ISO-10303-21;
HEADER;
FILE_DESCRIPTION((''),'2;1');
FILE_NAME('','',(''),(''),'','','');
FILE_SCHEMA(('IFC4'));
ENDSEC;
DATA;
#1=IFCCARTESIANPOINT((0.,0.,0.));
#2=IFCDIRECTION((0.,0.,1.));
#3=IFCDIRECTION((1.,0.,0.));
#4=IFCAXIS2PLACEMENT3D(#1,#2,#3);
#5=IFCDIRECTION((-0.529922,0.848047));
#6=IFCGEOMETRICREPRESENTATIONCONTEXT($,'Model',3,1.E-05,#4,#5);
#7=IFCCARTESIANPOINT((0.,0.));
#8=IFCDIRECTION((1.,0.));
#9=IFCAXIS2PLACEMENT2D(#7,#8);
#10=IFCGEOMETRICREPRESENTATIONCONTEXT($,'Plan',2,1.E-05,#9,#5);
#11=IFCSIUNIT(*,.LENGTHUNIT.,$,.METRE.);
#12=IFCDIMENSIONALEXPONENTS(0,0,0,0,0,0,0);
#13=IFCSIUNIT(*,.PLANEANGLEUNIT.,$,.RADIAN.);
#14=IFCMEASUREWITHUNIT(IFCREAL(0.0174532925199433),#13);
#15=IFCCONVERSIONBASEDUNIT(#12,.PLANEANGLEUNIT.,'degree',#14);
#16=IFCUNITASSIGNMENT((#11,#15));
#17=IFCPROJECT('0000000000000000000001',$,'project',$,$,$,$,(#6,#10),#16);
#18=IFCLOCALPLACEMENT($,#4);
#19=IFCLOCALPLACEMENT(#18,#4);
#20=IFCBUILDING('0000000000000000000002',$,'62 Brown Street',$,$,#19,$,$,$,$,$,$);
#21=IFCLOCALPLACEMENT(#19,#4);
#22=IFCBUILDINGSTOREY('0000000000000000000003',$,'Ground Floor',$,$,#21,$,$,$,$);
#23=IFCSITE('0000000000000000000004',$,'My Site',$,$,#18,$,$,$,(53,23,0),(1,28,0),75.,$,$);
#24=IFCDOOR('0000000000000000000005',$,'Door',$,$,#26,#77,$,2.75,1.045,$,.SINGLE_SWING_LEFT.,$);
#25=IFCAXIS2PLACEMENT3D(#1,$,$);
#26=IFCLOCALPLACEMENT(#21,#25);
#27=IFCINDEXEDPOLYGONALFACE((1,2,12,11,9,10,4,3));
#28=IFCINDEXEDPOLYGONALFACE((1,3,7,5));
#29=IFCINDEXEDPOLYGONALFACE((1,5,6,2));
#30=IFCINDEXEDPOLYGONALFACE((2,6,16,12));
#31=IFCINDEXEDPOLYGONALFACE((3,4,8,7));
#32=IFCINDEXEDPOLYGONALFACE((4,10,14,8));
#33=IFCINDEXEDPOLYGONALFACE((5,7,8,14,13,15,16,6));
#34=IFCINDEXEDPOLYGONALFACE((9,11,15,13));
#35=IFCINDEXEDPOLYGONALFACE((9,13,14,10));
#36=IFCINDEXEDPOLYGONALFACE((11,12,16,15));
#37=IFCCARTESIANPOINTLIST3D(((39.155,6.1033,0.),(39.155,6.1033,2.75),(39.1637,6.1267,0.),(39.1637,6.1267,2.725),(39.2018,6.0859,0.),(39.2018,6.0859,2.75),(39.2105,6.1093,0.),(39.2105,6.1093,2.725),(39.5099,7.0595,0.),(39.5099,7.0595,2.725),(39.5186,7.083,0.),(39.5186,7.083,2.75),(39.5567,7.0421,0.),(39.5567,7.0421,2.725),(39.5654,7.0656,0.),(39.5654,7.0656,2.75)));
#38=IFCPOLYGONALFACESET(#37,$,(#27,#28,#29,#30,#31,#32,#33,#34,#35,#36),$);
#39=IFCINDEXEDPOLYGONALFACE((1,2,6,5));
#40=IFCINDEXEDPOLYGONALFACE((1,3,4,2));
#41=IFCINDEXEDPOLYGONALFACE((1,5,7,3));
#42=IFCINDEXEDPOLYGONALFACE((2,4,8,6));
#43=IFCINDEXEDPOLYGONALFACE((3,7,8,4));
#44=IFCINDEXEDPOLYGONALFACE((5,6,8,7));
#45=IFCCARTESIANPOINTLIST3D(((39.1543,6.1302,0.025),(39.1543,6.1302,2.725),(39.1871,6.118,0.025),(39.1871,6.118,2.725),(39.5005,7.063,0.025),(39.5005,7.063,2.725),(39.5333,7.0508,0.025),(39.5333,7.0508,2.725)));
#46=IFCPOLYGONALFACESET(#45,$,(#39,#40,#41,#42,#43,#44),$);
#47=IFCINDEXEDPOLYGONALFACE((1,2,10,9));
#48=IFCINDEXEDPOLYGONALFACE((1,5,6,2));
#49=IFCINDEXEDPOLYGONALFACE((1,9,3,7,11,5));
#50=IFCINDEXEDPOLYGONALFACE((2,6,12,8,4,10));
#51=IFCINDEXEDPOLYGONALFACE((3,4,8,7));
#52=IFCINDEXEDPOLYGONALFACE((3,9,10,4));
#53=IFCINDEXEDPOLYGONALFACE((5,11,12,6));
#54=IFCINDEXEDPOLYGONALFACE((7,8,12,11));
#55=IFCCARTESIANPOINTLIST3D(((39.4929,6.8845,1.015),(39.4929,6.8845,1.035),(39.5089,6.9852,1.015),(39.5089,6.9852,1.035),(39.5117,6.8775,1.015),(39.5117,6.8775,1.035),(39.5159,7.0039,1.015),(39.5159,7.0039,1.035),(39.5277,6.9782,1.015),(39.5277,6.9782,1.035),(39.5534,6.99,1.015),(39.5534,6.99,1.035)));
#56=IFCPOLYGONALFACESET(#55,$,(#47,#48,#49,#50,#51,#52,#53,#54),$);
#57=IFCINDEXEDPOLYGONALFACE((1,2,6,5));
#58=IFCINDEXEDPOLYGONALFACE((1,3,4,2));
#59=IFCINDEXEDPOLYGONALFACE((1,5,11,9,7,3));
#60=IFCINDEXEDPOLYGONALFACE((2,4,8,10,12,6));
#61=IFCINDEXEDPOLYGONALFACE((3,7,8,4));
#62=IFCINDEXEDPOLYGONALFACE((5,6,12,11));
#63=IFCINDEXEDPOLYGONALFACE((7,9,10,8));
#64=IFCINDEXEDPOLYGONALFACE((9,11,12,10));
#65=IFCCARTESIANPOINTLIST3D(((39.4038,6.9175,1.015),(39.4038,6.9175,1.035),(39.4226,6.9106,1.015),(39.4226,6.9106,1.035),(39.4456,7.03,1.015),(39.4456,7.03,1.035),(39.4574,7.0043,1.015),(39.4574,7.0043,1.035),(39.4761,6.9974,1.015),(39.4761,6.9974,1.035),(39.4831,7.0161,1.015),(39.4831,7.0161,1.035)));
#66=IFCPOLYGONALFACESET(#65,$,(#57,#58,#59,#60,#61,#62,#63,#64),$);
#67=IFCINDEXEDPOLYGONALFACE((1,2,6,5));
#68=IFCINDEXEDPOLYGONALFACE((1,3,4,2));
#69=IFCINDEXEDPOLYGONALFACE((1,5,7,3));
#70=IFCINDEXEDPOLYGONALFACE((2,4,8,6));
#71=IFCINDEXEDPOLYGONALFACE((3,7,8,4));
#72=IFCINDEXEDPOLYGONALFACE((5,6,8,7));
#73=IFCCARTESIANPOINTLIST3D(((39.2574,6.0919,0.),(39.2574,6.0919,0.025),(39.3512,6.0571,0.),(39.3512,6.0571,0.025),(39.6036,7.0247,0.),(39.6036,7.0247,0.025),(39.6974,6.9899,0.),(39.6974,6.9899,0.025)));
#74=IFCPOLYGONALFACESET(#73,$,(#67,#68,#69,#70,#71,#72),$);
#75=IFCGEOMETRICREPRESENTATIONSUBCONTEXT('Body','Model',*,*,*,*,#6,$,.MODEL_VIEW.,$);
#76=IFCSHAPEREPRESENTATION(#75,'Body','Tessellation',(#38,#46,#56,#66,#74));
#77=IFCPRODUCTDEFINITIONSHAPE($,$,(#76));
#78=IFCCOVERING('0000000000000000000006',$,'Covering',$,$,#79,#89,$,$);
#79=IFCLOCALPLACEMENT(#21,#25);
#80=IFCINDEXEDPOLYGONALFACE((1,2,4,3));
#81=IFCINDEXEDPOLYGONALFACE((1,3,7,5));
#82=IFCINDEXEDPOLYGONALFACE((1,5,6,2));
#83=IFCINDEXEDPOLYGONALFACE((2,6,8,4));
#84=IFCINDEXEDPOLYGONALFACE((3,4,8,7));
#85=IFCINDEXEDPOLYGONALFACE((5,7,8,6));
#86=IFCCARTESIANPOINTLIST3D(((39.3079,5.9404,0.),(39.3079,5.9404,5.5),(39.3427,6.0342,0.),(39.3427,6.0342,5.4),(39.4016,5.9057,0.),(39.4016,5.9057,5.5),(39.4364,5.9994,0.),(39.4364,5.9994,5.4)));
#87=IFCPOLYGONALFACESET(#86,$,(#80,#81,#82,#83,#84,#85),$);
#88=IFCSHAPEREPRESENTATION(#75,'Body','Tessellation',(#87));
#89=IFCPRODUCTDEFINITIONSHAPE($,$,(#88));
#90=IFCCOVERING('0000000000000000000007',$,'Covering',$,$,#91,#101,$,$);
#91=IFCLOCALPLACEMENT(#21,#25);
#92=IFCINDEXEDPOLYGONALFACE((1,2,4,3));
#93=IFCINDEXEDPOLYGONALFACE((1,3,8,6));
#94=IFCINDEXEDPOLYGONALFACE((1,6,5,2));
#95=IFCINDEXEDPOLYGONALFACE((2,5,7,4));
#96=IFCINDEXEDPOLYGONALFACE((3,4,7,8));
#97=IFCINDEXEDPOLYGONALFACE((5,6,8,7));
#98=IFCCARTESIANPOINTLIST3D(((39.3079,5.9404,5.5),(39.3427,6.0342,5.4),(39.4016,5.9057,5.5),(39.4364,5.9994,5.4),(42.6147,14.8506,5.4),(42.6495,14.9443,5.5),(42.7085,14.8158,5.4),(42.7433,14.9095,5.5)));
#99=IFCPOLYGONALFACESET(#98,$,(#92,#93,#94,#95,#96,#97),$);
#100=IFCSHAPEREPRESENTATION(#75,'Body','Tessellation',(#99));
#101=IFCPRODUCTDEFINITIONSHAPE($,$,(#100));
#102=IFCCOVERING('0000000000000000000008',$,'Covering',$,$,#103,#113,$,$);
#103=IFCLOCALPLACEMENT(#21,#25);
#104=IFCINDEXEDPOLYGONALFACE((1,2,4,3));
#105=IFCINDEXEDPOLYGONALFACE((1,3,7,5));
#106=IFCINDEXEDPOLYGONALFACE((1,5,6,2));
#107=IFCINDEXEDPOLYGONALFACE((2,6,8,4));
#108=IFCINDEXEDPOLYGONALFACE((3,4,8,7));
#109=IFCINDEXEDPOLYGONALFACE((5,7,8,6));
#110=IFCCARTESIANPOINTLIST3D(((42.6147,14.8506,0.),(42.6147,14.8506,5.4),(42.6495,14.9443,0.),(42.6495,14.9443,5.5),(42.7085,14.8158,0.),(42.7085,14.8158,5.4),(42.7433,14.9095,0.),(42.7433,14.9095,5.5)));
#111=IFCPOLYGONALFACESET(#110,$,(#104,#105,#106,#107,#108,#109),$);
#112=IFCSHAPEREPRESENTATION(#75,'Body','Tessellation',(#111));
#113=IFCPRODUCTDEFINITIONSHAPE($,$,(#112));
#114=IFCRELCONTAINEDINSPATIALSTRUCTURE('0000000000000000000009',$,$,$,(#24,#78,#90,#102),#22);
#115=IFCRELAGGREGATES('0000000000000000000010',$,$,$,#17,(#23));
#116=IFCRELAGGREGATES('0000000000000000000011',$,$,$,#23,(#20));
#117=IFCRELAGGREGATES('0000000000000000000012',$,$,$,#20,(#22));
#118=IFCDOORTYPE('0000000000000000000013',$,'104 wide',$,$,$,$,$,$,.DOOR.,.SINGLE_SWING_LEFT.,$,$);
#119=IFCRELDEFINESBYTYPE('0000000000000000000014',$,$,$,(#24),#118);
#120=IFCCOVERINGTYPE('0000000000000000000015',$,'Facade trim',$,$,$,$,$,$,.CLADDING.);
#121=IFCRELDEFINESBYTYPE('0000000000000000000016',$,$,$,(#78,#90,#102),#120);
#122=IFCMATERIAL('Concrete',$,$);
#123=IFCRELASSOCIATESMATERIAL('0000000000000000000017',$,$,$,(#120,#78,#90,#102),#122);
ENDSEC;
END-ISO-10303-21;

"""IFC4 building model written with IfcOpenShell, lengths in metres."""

from ifc_helpers import new_model, entity, si_unit, converted_unit, direction, frame, origin_with_axes, origin_2d_with_axis, place, context, subcontext, project, spatial, line, indexed_curve, rectangle, outline, extrude, clip, halfspace, shape, source, transform, mapped, material, material_profile, profile_set, profile_usage, type_object, type_shapes, element, save


model = new_model("IFC4")

# Units and contexts
model_context = context("Model", 3, precision=1e-05, world=origin_with_axes(), true_north=direction((-0.529922, 0.848047)))
plan_context = context("Plan", 2, precision=1e-05, world=origin_2d_with_axis(), true_north=direction((-0.529922, 0.848047)))
body_context_1 = subcontext(model_context, "Body", "Model", "MODEL_VIEW")
body_context_2 = subcontext(plan_context, "Body", "Plan", "PLAN_VIEW")
ifc_project = project(units=[si_unit("LENGTHUNIT", "METRE"), converted_unit("PLANEANGLEUNIT", "degree", entity("IfcReal", 0.0174532925199433), si_unit("PLANEANGLEUNIT", "RADIAN"), dimensions=[0, 0, 0, 0, 0, 0, 0])], contexts=[model_context, plan_context])

# Site, building, storey
site_placement = place(None, origin_with_axes())
site = spatial("IfcSite", under=ifc_project, at=site_placement, Name="My Site", RefLatitude=(53, 23, 0), RefLongitude=(1, 28, 0), RefElevation=75.0)
building_placement = place(site_placement, origin_with_axes())
building = spatial("IfcBuilding", under=site, at=building_placement, Name="62 Brown Street")
storey_placement = place(building_placement, origin_with_axes())
storey = spatial("IfcBuildingStorey", under=building, at=storey_placement, Name="Ground Floor")

# Shared definitions
ifc_material_1 = material(Name="Concrete")

# Shared definitions
placement_1 = place(storey_placement, frame((39.024, 5.1755, 0.0), z_axis=(0.0, 0.0, 1.0), x_axis=(0.347944, 0.937515, 0.0)))

# Door
door_type_1 = type_object("IfcDoorType", Name="104 wide", OperationType="SINGLE_SWING_LEFT", PredefinedType="DOOR")
shared_shape_1 = source(origin_with_axes(), body_context_1, "Body", "SweptSolid", [
    extrude(outline(indexed_curve([(0.0, 0.0), (0.0, 2.75), (1.045, 2.75), (1.045, 0.0), (1.02, 0.0), (1.02, 2.725), (0.025, 2.725), (0.025, 0.0)], segments=[line(1, 2, 3, 4, 5, 6, 7, 8, 1)])), frame((0.0, 0.15, 0.0), z_axis=(0.0, -1.0, 0.0), x_axis=(1.0, 0.0, 0.0)), (0.0, 0.0, -1.0), 0.05),
    extrude(outline(indexed_curve([(0.0, 0.0), (0.995, 0.0), (0.995, 0.035), (0.0, 0.035)], segments=[line(1, 2, 3, 4, 1)])), frame((0.025, 0.175, 0.025), z_axis=(0.0, 0.0, 1.0), x_axis=(1.0, 0.0, 0.0)), (0.0, 0.0, 1.0), 2.7),
    extrude(outline(indexed_curve([(0.0, 0.0), (0.0, -0.04), (-0.12, -0.04), (-0.12, -0.02), (-0.02, -0.02), (-0.02, 0.0)], segments=[line(1, 2, 3, 4, 5, 6, 1)])), frame((0.97, 0.175, 1.015), z_axis=(0.0, 0.0, 1.0), x_axis=(1.0, 0.0, 0.0)), (0.0, 0.0, 1.0), 0.02),
    extrude(outline(indexed_curve([(0.0, 0.0), (0.0, 0.04), (-0.12, 0.04), (-0.12, 0.02), (-0.02, 0.02), (-0.02, 0.0)], segments=[line(1, 2, 3, 4, 5, 6, 1)])), frame((0.97, 0.21, 1.015), z_axis=(0.0, 0.0, 1.0), x_axis=(1.0, 0.0, 0.0)), (0.0, 0.0, 1.0), 0.02),
    extrude(outline(indexed_curve([(0.0, 0.0), (0.995, 0.0), (0.995, 0.1), (0.0, 0.1)], segments=[line(1, 2, 3, 4, 1)])), frame((0.025, 0.0, 0.0), z_axis=(0.0, 0.0, 1.0), x_axis=(1.0, 0.0, 0.0)), (0.0, 0.0, 1.0), 0.025),
])
shared_shape_2 = source(origin_with_axes(), body_context_2, "Body", "Curve2D", [
    entity("IfcIndexedPolyCurve", entity("IfcCartesianPointList2D", [[0.0, 0.15], [0.025, 0.15], [0.025, 0.2], [0.0, 0.2]]), [entity("IfcLineIndex", [1, 2, 3, 4, 1])]),
    entity("IfcIndexedPolyCurve", entity("IfcCartesianPointList2D", [[1.045, 0.15], [1.02, 0.15], [1.02, 0.2], [1.045, 0.2]]), [entity("IfcLineIndex", [1, 2, 3, 4, 1])]),
    entity("IfcTrimmedCurve", entity("IfcEllipse", entity("IfcAxis2Placement2D", entity("IfcCartesianPoint", [0.06, 0.2]), entity("IfcDirection", [1.0, 0.0])), 0.96, 0.995), [entity("IfcCartesianPoint", [1.02, 0.2])], [entity("IfcCartesianPoint", [0.06, 1.195])], True, "CARTESIAN"),
    entity("IfcIndexedPolyCurve", entity("IfcCartesianPointList2D", [[0.025, 0.2], [0.06, 0.2], [0.06, 1.195], [0.025, 1.195]]), [entity("IfcLineIndex", [1, 2, 3, 4, 1])]),
])
type_shapes(door_type_1, [shared_shape_1, shared_shape_2])
placement_2 = place(placement_1, frame((0.9154, 0.0, 0.0), z_axis=(0.0, 0.0, 1.0), x_axis=(1.0, 0.0, 0.0)))
door_1_placement = place(placement_2, frame((0.0, 0.0, 0.0), z_axis=(0.0, 0.0, 1.0), x_axis=(1.0, 0.0, 0.0)))
element("IfcDoor", 1, at=door_1_placement, inside=storey, type_object=door_type_1, Name="Door", OperationType="SINGLE_SWING_LEFT", OverallHeight=2.75, OverallWidth=1.045, shapes=[
    shape(body_context_1, "Body", "MappedRepresentation", [mapped(shared_shape_1, transform((0.0, 0.0, 0.0), x_axis=(1.0, 0.0, 0.0), y_axis=(0.0, 1.0, 0.0), z_axis=(0.0, 0.0, 1.0), scale=1.0))]),
    shape(body_context_2, "Body", "MappedRepresentation", [mapped(shared_shape_2, transform((0.0, 0.0, 0.0), x_axis=(1.0, 0.0, 0.0), y_axis=(0.0, 1.0, 0.0), z_axis=(0.0, 0.0, 1.0), scale=1.0))]),
])

# Coverings
ifc_material_profile = material_profile(ifc_material_1, rectangle(XDim=0.1, YDim=0.1))
ifc_profile_set = profile_set([ifc_material_profile], Name="cowl")
ifc_profile_usage_1 = profile_usage(ifc_profile_set, cardinal=5)
covering_type = type_object("IfcCoveringType", Name="Facade trim", PredefinedType="CLADDING", material=ifc_profile_set)
covering_1_placement = place(storey_placement, frame((39.3721, 5.9699, 0.0), z_axis=(0.0, 0.0, 1.0), x_axis=(0.347944, 0.937515, 0.0)))
element("IfcCovering", 2, at=covering_1_placement, inside=storey, type_object=covering_type, material=ifc_profile_usage_1, Name="Covering", context=body_context_1, shape_type="Clipping", body=[
    clip(extrude(rectangle(XDim=0.1, YDim=0.1), origin_with_axes(), (0.0, 0.0, 1.0), 5.5), halfspace(frame((-0.05, 34.8348, 5.5), z_axis=(0.707098, 0.0, 0.707116), x_axis=(0.707116, 0.0, -0.707098)), False)),
])
ifc_profile_usage_2 = profile_usage(ifc_profile_set, cardinal=5)
covering_2_placement = place(storey_placement, frame((39.3547, 5.923, 5.45), z_axis=(0.347944, 0.937515, 0.0), x_axis=(0.0, 0.0, -1.0)))
element("IfcCovering", 3, at=covering_2_placement, inside=storey, type_object=covering_type, material=ifc_profile_usage_2, Name="Covering", context=body_context_1, shape_type="Clipping", body=[
    clip(clip(extrude(rectangle(XDim=0.1, YDim=0.1), origin_with_axes(), (0.0, 0.0, 1.0), 9.604), halfspace(frame((-0.05, 34.8348, 9.604), z_axis=(0.707114, 0.0, 0.7071), x_axis=(0.7071, -0.000003, -0.707113)), False)), halfspace(frame((-0.05, 34.8348, 0.0), z_axis=(0.707116, 0.0, -0.707098), x_axis=(0.707098, 0.0, 0.707116)), False)),
])
ifc_profile_usage_3 = profile_usage(ifc_profile_set, cardinal=5)
covering_3_placement = place(storey_placement, frame((42.679, 14.8801, 5.5), z_axis=(0.0, 0.0, -1.0), x_axis=(-0.347944, -0.937515, 0.0)))
element("IfcCovering", 4, at=covering_3_placement, inside=storey, type_object=covering_type, material=ifc_profile_usage_3, Name="Covering", context=body_context_1, shape_type="Clipping", body=[
    clip(extrude(rectangle(XDim=0.1, YDim=0.1), origin_with_axes(), (0.0, 0.0, 1.0), 5.5), halfspace(frame((-0.05, 34.8348, 0.0), z_axis=(0.7071, 0.0, -0.707113), x_axis=(0.707113, -0.000003, 0.7071)), False)),
])

save(model, "model.ifc")
